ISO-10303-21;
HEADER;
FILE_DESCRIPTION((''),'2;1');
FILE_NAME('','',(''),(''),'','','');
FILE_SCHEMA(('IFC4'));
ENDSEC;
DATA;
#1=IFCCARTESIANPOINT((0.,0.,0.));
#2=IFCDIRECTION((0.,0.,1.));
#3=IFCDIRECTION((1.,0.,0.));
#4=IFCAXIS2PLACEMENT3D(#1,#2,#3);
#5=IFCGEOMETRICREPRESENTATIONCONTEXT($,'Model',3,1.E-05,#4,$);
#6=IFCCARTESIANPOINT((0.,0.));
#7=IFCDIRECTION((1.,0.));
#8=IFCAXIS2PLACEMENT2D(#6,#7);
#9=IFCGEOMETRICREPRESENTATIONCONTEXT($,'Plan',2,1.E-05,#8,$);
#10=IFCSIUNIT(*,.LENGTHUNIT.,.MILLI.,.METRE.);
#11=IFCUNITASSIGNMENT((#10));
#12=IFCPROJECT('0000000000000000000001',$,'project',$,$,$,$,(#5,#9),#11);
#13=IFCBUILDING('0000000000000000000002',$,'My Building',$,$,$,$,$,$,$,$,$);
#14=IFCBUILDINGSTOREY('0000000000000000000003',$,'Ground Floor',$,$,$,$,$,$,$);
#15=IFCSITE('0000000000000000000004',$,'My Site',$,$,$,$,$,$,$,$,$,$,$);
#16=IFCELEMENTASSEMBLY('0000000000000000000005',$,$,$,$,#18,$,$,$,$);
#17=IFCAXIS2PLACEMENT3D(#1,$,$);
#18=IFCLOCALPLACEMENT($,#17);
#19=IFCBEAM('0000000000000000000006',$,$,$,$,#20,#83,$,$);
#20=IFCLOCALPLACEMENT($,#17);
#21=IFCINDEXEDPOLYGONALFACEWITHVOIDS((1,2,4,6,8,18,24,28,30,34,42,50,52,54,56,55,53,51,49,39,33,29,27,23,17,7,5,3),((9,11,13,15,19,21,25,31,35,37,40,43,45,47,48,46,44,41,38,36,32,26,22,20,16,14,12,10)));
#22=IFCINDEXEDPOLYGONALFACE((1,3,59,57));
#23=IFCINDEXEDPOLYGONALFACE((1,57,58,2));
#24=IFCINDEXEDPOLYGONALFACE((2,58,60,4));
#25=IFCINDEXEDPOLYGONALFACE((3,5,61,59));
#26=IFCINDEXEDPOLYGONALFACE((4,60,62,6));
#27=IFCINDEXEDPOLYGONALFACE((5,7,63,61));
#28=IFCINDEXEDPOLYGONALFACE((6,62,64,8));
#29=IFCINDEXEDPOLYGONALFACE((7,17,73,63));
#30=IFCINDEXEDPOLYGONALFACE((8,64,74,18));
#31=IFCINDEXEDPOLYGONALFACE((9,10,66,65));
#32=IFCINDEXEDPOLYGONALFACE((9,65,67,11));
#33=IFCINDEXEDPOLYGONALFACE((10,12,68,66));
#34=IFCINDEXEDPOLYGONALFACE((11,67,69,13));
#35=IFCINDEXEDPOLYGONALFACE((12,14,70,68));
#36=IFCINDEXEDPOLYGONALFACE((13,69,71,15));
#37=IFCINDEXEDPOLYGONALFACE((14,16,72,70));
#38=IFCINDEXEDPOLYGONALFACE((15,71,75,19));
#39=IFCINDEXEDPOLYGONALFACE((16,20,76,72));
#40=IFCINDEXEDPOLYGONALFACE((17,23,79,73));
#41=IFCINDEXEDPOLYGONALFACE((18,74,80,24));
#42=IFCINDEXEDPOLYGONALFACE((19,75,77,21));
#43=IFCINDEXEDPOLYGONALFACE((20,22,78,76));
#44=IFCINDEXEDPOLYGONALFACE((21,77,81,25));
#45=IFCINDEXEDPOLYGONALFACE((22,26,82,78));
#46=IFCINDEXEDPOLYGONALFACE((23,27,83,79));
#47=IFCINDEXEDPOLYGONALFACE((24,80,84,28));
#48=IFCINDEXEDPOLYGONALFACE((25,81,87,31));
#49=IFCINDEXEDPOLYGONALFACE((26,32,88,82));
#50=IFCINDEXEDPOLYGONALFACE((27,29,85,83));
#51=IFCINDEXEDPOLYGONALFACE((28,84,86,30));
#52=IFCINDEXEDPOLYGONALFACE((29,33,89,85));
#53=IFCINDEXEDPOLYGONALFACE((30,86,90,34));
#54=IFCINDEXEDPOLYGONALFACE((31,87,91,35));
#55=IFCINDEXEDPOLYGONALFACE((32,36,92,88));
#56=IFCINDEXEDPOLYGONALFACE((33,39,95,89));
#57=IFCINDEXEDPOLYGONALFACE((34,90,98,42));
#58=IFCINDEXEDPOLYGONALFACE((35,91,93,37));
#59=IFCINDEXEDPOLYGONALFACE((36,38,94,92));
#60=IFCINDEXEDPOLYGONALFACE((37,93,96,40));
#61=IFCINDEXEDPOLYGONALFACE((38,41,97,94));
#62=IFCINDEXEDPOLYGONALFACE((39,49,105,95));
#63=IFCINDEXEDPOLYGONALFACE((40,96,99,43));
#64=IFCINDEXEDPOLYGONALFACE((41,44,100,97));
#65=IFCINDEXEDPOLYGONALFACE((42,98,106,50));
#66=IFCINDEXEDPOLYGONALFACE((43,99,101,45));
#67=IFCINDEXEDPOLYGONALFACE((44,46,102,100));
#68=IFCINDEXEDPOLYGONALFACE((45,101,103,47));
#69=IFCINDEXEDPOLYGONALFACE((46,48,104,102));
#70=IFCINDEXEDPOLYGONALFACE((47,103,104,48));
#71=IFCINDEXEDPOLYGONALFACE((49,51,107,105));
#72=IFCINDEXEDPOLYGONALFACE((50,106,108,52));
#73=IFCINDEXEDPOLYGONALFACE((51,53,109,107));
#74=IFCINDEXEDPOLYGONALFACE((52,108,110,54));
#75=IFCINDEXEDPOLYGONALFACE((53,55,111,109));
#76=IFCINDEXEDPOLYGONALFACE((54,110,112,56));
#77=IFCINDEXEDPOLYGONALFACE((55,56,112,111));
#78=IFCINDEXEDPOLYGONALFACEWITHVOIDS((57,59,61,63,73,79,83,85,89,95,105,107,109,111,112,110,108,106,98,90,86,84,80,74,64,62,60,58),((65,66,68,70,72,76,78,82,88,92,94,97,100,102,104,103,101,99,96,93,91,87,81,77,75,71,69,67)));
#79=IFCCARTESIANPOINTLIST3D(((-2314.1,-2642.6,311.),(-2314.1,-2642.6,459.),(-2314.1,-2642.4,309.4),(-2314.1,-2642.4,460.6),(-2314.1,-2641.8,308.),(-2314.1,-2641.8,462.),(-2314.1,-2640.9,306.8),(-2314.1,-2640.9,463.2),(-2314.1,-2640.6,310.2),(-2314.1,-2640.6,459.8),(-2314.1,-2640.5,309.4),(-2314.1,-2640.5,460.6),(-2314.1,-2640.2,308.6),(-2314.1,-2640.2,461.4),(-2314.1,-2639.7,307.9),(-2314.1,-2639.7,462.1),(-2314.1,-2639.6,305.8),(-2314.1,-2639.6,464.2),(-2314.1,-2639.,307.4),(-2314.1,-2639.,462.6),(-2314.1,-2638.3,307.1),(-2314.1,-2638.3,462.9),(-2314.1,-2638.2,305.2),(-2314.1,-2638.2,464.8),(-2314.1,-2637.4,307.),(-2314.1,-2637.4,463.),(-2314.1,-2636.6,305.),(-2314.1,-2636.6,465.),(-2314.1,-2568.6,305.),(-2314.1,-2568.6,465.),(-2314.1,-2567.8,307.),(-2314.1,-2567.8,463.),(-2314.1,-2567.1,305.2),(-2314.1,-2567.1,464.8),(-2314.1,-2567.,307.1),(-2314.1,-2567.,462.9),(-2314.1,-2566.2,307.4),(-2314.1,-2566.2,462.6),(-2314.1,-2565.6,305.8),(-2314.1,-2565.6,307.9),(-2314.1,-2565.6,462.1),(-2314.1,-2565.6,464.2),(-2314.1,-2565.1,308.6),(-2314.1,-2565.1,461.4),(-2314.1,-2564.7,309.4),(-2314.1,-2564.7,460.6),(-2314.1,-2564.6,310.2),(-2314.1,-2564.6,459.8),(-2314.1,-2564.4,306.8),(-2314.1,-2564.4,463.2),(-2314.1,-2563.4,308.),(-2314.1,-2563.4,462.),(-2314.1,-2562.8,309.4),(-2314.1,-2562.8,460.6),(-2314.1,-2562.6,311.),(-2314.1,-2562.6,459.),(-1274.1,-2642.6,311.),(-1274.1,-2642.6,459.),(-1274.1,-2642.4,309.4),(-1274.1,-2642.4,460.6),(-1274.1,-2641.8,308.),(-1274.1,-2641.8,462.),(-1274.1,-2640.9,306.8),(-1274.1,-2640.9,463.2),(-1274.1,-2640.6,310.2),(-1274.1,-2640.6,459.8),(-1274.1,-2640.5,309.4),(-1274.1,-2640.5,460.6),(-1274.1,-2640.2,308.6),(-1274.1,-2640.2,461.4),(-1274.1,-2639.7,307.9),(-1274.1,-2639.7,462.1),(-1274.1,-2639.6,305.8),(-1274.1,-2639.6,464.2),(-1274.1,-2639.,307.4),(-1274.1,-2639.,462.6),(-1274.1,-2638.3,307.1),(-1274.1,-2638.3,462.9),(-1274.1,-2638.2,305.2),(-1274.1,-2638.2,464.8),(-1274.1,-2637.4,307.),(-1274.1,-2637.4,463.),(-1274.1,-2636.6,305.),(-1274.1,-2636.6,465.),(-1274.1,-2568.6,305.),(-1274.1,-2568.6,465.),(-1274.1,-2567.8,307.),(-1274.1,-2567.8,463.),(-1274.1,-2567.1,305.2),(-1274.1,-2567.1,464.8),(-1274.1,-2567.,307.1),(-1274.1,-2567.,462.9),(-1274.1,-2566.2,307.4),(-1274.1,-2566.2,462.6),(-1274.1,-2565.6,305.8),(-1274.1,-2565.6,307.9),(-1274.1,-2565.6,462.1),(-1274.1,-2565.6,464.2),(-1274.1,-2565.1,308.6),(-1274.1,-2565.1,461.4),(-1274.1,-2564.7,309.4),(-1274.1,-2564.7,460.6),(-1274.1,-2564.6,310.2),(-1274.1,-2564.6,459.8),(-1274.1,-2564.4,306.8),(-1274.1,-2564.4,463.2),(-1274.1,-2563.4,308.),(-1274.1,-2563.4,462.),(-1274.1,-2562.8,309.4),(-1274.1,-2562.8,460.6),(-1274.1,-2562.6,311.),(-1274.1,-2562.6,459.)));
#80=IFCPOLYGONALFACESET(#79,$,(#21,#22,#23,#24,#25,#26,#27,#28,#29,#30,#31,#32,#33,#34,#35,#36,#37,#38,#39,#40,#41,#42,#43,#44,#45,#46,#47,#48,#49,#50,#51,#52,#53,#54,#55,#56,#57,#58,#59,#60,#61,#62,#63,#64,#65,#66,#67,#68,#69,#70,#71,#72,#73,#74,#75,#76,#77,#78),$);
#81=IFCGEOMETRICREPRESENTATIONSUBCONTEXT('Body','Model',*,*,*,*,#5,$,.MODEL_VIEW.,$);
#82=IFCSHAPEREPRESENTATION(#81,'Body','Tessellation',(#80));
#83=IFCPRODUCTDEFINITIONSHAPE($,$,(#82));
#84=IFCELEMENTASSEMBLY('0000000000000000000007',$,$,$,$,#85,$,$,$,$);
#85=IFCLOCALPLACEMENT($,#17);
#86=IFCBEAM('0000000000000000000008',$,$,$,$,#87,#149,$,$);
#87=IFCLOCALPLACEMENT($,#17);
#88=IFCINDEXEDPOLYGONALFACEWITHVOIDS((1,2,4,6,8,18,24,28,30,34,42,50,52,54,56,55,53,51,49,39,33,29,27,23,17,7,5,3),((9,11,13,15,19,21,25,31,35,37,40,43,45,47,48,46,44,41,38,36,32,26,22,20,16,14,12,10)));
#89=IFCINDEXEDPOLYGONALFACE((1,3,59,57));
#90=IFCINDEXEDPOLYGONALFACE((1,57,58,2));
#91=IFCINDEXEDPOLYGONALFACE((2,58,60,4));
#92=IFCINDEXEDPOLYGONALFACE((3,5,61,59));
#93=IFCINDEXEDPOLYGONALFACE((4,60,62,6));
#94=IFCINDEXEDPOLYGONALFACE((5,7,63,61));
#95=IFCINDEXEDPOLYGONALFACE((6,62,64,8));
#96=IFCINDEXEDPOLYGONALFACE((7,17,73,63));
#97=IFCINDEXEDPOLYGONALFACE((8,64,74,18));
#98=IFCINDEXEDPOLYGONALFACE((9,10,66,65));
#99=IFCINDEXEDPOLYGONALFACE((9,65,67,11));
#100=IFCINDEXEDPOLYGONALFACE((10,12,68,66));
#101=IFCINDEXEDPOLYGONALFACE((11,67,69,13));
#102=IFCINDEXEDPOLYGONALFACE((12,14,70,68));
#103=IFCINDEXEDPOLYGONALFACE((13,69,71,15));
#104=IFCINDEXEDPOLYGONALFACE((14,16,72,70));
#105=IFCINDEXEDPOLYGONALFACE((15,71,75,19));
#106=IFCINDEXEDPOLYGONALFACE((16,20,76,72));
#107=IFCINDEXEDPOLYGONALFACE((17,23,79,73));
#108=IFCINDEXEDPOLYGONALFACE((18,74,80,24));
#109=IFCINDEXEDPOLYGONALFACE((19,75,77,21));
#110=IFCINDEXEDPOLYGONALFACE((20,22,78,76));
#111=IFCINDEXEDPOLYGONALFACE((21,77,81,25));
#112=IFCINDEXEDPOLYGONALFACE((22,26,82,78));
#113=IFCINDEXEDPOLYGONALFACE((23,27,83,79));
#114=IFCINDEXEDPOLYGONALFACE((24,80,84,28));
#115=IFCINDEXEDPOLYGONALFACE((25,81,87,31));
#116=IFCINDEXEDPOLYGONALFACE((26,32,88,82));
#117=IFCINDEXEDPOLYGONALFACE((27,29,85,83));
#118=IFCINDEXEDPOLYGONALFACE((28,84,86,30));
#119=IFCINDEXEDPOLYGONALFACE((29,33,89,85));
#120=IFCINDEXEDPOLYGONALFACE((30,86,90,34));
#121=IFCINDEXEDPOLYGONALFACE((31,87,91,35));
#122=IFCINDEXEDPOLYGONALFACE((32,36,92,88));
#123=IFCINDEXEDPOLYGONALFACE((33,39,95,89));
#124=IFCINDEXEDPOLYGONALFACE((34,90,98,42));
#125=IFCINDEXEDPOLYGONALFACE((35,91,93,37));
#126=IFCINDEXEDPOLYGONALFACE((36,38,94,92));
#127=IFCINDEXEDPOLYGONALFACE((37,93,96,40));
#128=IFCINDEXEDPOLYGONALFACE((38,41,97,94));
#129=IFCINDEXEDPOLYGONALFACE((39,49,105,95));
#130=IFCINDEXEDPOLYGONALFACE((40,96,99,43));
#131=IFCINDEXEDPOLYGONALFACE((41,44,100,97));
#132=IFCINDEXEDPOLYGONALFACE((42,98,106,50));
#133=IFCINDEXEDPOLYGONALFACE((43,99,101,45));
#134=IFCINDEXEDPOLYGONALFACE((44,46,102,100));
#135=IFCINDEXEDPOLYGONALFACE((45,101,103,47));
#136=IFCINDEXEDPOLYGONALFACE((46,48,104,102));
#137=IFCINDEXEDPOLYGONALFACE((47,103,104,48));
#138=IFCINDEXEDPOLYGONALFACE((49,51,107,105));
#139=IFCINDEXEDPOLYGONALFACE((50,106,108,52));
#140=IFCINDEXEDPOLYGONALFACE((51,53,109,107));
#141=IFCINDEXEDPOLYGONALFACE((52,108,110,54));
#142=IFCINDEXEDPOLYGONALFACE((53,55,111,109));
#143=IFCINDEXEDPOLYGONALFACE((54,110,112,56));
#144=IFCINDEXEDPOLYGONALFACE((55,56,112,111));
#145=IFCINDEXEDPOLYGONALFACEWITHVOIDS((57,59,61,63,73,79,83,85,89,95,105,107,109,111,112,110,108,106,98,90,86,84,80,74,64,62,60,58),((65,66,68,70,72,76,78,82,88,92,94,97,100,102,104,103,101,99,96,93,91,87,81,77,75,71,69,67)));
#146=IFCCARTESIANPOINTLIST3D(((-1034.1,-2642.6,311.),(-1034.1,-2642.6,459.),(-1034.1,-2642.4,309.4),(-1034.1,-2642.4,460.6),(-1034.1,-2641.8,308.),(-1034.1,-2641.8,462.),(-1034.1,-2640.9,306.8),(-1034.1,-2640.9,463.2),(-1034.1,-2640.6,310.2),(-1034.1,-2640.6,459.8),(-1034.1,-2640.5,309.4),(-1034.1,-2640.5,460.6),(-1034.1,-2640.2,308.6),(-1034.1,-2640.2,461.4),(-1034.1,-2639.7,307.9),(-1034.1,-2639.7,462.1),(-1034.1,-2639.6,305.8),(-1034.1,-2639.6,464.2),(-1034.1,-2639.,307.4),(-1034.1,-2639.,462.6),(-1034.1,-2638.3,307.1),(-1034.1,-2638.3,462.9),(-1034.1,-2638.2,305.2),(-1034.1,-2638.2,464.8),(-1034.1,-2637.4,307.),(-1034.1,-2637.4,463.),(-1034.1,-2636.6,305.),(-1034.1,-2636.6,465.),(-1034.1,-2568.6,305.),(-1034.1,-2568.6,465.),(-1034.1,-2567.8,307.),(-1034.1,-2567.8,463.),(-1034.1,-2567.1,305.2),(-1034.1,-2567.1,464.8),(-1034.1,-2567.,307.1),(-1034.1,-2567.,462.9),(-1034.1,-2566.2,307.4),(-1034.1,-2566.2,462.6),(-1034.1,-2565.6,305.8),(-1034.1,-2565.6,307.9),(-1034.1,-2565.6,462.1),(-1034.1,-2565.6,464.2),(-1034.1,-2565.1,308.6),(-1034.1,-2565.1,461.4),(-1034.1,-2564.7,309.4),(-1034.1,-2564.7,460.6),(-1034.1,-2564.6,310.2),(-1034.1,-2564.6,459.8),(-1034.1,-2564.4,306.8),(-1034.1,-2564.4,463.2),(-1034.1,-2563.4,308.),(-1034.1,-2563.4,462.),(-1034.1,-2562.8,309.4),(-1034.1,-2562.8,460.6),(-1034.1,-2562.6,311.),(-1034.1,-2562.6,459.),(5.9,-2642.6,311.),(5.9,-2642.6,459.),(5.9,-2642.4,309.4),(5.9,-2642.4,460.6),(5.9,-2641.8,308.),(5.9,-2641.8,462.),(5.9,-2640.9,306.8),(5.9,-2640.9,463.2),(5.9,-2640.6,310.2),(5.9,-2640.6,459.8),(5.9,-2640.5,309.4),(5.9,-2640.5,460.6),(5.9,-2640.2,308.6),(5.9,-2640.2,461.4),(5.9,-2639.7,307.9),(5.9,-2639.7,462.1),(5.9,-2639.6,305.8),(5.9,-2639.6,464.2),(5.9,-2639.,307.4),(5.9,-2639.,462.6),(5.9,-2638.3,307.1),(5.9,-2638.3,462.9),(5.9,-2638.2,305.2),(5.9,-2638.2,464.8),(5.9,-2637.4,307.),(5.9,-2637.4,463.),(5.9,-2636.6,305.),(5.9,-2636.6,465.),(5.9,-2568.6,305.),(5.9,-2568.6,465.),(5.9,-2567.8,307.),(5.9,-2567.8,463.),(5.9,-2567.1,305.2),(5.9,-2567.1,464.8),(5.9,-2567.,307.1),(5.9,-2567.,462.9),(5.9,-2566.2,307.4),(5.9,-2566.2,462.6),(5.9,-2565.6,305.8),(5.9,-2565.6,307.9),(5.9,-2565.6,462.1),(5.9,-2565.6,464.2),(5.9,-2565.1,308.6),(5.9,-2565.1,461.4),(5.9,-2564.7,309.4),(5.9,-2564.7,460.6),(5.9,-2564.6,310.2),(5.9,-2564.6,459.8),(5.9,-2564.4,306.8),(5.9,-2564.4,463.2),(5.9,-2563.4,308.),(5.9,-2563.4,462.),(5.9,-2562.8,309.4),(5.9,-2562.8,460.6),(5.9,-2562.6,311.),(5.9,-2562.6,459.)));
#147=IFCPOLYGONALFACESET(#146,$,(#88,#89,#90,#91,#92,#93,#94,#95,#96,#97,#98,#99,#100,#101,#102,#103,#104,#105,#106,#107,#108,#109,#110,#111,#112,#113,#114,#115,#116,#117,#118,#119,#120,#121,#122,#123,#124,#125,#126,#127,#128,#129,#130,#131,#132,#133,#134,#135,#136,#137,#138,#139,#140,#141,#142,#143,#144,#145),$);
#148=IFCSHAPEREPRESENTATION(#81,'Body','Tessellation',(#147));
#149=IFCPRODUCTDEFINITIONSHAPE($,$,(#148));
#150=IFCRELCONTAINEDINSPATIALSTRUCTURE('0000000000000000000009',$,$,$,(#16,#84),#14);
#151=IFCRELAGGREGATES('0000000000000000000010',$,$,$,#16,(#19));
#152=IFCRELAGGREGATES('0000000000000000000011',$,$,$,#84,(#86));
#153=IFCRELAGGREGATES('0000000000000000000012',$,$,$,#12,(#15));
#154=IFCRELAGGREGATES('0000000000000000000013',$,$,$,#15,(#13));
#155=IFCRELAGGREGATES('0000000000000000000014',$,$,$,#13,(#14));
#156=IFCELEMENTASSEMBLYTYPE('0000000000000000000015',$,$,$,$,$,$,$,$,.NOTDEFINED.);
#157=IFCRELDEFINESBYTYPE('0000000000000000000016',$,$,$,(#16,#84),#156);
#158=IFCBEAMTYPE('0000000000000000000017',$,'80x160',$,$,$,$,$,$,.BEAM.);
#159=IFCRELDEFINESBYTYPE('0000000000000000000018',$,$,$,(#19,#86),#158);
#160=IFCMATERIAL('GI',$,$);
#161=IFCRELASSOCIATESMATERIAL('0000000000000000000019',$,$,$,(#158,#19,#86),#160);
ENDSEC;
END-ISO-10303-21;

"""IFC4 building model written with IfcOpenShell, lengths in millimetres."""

from ifc_helpers import new_model, si_unit, frame, origin_with_axes, origin_2d_with_axis, place, context, subcontext, project, spatial, hollow_rectangle, extrude, material, material_profile, profile_set, profile_usage, type_object, element, aggregate, save


model = new_model("IFC4")

# Units and contexts
model_context = context("Model", 3, precision=1e-05, world=origin_with_axes())
plan_context = context("Plan", 2, precision=1e-05, world=origin_2d_with_axis())
body_context = subcontext(model_context, "Body", "Model", "MODEL_VIEW")
ifc_project = project(units=[si_unit("LENGTHUNIT", "METRE", prefix="MILLI")], contexts=[model_context, plan_context])

# Site, building, storey
site = spatial("IfcSite", under=ifc_project, Name="My Site")
building = spatial("IfcBuilding", under=site, Name="My Building")
storey = spatial("IfcBuildingStorey", under=building, Name="Ground Floor")

# Shared definitions
ifc_material_1 = material(Name="GI")

# Element assemblies, beams
element_assembly_type_1 = type_object("IfcElementAssemblyType", PredefinedType="NOTDEFINED")
ifc_material_profile_1 = material_profile(ifc_material_1, hollow_rectangle(XDim=80.0, YDim=160.0, WallThickness=2.0, InnerFilletRadius=3.2, OuterFilletRadius=6.0))
ifc_profile_set_1 = profile_set([ifc_material_profile_1], Name="80x160 GI Rectangular Hollow")
beam_type = type_object("IfcBeamType", Name="80x160", PredefinedType="BEAM", material=ifc_profile_set_1)
assembly_1_placement = place(None, frame((-2394.1, -2602.6, 385.0), z_axis=(1.0, 0.0, 0.0), x_axis=(0.0, 1.0, 0.0)))
assembly_1 = element("IfcElementAssembly", 1, at=assembly_1_placement, inside=storey, type_object=element_assembly_type_1)
ifc_profile_usage_1 = profile_usage(ifc_profile_set_1)
beam_1_placement = place(assembly_1_placement, frame((0.0, 0.0, 80.0), z_axis=(0.0, 0.0, 1.0), x_axis=(1.0, 0.0, 0.0)))
beam_1 = element("IfcBeam", 2, at=beam_1_placement, type_object=beam_type, material=ifc_profile_usage_1, context=body_context, shape_type="SweptSolid", body=[
    extrude(hollow_rectangle(XDim=80.0, YDim=160.0, WallThickness=2.0, InnerFilletRadius=3.2, OuterFilletRadius=6.0), origin_with_axes(), (0.0, 0.0, 1.0), 1040.0),
])
aggregate(assembly_1, [beam_1])
assembly_2_placement = place(None, frame((-1114.1, -2602.6, 385.0), z_axis=(1.0, 0.0, 0.0), x_axis=(0.0, 1.0, 0.0)))
assembly_2 = element("IfcElementAssembly", 3, at=assembly_2_placement, inside=storey, type_object=element_assembly_type_1)
ifc_profile_usage_2 = profile_usage(ifc_profile_set_1)
beam_2_placement = place(assembly_2_placement, frame((0.0, 0.0, 80.0), z_axis=(0.0, 0.0, 1.0), x_axis=(1.0, 0.0, 0.0)))
beam_2 = element("IfcBeam", 4, at=beam_2_placement, type_object=beam_type, material=ifc_profile_usage_2, context=body_context, shape_type="SweptSolid", body=[
    extrude(hollow_rectangle(XDim=80.0, YDim=160.0, WallThickness=2.0, InnerFilletRadius=3.2, OuterFilletRadius=6.0), origin_with_axes(), (0.0, 0.0, 1.0), 1040.0),
])
aggregate(assembly_2, [beam_2])

save(model, "model.ifc")
